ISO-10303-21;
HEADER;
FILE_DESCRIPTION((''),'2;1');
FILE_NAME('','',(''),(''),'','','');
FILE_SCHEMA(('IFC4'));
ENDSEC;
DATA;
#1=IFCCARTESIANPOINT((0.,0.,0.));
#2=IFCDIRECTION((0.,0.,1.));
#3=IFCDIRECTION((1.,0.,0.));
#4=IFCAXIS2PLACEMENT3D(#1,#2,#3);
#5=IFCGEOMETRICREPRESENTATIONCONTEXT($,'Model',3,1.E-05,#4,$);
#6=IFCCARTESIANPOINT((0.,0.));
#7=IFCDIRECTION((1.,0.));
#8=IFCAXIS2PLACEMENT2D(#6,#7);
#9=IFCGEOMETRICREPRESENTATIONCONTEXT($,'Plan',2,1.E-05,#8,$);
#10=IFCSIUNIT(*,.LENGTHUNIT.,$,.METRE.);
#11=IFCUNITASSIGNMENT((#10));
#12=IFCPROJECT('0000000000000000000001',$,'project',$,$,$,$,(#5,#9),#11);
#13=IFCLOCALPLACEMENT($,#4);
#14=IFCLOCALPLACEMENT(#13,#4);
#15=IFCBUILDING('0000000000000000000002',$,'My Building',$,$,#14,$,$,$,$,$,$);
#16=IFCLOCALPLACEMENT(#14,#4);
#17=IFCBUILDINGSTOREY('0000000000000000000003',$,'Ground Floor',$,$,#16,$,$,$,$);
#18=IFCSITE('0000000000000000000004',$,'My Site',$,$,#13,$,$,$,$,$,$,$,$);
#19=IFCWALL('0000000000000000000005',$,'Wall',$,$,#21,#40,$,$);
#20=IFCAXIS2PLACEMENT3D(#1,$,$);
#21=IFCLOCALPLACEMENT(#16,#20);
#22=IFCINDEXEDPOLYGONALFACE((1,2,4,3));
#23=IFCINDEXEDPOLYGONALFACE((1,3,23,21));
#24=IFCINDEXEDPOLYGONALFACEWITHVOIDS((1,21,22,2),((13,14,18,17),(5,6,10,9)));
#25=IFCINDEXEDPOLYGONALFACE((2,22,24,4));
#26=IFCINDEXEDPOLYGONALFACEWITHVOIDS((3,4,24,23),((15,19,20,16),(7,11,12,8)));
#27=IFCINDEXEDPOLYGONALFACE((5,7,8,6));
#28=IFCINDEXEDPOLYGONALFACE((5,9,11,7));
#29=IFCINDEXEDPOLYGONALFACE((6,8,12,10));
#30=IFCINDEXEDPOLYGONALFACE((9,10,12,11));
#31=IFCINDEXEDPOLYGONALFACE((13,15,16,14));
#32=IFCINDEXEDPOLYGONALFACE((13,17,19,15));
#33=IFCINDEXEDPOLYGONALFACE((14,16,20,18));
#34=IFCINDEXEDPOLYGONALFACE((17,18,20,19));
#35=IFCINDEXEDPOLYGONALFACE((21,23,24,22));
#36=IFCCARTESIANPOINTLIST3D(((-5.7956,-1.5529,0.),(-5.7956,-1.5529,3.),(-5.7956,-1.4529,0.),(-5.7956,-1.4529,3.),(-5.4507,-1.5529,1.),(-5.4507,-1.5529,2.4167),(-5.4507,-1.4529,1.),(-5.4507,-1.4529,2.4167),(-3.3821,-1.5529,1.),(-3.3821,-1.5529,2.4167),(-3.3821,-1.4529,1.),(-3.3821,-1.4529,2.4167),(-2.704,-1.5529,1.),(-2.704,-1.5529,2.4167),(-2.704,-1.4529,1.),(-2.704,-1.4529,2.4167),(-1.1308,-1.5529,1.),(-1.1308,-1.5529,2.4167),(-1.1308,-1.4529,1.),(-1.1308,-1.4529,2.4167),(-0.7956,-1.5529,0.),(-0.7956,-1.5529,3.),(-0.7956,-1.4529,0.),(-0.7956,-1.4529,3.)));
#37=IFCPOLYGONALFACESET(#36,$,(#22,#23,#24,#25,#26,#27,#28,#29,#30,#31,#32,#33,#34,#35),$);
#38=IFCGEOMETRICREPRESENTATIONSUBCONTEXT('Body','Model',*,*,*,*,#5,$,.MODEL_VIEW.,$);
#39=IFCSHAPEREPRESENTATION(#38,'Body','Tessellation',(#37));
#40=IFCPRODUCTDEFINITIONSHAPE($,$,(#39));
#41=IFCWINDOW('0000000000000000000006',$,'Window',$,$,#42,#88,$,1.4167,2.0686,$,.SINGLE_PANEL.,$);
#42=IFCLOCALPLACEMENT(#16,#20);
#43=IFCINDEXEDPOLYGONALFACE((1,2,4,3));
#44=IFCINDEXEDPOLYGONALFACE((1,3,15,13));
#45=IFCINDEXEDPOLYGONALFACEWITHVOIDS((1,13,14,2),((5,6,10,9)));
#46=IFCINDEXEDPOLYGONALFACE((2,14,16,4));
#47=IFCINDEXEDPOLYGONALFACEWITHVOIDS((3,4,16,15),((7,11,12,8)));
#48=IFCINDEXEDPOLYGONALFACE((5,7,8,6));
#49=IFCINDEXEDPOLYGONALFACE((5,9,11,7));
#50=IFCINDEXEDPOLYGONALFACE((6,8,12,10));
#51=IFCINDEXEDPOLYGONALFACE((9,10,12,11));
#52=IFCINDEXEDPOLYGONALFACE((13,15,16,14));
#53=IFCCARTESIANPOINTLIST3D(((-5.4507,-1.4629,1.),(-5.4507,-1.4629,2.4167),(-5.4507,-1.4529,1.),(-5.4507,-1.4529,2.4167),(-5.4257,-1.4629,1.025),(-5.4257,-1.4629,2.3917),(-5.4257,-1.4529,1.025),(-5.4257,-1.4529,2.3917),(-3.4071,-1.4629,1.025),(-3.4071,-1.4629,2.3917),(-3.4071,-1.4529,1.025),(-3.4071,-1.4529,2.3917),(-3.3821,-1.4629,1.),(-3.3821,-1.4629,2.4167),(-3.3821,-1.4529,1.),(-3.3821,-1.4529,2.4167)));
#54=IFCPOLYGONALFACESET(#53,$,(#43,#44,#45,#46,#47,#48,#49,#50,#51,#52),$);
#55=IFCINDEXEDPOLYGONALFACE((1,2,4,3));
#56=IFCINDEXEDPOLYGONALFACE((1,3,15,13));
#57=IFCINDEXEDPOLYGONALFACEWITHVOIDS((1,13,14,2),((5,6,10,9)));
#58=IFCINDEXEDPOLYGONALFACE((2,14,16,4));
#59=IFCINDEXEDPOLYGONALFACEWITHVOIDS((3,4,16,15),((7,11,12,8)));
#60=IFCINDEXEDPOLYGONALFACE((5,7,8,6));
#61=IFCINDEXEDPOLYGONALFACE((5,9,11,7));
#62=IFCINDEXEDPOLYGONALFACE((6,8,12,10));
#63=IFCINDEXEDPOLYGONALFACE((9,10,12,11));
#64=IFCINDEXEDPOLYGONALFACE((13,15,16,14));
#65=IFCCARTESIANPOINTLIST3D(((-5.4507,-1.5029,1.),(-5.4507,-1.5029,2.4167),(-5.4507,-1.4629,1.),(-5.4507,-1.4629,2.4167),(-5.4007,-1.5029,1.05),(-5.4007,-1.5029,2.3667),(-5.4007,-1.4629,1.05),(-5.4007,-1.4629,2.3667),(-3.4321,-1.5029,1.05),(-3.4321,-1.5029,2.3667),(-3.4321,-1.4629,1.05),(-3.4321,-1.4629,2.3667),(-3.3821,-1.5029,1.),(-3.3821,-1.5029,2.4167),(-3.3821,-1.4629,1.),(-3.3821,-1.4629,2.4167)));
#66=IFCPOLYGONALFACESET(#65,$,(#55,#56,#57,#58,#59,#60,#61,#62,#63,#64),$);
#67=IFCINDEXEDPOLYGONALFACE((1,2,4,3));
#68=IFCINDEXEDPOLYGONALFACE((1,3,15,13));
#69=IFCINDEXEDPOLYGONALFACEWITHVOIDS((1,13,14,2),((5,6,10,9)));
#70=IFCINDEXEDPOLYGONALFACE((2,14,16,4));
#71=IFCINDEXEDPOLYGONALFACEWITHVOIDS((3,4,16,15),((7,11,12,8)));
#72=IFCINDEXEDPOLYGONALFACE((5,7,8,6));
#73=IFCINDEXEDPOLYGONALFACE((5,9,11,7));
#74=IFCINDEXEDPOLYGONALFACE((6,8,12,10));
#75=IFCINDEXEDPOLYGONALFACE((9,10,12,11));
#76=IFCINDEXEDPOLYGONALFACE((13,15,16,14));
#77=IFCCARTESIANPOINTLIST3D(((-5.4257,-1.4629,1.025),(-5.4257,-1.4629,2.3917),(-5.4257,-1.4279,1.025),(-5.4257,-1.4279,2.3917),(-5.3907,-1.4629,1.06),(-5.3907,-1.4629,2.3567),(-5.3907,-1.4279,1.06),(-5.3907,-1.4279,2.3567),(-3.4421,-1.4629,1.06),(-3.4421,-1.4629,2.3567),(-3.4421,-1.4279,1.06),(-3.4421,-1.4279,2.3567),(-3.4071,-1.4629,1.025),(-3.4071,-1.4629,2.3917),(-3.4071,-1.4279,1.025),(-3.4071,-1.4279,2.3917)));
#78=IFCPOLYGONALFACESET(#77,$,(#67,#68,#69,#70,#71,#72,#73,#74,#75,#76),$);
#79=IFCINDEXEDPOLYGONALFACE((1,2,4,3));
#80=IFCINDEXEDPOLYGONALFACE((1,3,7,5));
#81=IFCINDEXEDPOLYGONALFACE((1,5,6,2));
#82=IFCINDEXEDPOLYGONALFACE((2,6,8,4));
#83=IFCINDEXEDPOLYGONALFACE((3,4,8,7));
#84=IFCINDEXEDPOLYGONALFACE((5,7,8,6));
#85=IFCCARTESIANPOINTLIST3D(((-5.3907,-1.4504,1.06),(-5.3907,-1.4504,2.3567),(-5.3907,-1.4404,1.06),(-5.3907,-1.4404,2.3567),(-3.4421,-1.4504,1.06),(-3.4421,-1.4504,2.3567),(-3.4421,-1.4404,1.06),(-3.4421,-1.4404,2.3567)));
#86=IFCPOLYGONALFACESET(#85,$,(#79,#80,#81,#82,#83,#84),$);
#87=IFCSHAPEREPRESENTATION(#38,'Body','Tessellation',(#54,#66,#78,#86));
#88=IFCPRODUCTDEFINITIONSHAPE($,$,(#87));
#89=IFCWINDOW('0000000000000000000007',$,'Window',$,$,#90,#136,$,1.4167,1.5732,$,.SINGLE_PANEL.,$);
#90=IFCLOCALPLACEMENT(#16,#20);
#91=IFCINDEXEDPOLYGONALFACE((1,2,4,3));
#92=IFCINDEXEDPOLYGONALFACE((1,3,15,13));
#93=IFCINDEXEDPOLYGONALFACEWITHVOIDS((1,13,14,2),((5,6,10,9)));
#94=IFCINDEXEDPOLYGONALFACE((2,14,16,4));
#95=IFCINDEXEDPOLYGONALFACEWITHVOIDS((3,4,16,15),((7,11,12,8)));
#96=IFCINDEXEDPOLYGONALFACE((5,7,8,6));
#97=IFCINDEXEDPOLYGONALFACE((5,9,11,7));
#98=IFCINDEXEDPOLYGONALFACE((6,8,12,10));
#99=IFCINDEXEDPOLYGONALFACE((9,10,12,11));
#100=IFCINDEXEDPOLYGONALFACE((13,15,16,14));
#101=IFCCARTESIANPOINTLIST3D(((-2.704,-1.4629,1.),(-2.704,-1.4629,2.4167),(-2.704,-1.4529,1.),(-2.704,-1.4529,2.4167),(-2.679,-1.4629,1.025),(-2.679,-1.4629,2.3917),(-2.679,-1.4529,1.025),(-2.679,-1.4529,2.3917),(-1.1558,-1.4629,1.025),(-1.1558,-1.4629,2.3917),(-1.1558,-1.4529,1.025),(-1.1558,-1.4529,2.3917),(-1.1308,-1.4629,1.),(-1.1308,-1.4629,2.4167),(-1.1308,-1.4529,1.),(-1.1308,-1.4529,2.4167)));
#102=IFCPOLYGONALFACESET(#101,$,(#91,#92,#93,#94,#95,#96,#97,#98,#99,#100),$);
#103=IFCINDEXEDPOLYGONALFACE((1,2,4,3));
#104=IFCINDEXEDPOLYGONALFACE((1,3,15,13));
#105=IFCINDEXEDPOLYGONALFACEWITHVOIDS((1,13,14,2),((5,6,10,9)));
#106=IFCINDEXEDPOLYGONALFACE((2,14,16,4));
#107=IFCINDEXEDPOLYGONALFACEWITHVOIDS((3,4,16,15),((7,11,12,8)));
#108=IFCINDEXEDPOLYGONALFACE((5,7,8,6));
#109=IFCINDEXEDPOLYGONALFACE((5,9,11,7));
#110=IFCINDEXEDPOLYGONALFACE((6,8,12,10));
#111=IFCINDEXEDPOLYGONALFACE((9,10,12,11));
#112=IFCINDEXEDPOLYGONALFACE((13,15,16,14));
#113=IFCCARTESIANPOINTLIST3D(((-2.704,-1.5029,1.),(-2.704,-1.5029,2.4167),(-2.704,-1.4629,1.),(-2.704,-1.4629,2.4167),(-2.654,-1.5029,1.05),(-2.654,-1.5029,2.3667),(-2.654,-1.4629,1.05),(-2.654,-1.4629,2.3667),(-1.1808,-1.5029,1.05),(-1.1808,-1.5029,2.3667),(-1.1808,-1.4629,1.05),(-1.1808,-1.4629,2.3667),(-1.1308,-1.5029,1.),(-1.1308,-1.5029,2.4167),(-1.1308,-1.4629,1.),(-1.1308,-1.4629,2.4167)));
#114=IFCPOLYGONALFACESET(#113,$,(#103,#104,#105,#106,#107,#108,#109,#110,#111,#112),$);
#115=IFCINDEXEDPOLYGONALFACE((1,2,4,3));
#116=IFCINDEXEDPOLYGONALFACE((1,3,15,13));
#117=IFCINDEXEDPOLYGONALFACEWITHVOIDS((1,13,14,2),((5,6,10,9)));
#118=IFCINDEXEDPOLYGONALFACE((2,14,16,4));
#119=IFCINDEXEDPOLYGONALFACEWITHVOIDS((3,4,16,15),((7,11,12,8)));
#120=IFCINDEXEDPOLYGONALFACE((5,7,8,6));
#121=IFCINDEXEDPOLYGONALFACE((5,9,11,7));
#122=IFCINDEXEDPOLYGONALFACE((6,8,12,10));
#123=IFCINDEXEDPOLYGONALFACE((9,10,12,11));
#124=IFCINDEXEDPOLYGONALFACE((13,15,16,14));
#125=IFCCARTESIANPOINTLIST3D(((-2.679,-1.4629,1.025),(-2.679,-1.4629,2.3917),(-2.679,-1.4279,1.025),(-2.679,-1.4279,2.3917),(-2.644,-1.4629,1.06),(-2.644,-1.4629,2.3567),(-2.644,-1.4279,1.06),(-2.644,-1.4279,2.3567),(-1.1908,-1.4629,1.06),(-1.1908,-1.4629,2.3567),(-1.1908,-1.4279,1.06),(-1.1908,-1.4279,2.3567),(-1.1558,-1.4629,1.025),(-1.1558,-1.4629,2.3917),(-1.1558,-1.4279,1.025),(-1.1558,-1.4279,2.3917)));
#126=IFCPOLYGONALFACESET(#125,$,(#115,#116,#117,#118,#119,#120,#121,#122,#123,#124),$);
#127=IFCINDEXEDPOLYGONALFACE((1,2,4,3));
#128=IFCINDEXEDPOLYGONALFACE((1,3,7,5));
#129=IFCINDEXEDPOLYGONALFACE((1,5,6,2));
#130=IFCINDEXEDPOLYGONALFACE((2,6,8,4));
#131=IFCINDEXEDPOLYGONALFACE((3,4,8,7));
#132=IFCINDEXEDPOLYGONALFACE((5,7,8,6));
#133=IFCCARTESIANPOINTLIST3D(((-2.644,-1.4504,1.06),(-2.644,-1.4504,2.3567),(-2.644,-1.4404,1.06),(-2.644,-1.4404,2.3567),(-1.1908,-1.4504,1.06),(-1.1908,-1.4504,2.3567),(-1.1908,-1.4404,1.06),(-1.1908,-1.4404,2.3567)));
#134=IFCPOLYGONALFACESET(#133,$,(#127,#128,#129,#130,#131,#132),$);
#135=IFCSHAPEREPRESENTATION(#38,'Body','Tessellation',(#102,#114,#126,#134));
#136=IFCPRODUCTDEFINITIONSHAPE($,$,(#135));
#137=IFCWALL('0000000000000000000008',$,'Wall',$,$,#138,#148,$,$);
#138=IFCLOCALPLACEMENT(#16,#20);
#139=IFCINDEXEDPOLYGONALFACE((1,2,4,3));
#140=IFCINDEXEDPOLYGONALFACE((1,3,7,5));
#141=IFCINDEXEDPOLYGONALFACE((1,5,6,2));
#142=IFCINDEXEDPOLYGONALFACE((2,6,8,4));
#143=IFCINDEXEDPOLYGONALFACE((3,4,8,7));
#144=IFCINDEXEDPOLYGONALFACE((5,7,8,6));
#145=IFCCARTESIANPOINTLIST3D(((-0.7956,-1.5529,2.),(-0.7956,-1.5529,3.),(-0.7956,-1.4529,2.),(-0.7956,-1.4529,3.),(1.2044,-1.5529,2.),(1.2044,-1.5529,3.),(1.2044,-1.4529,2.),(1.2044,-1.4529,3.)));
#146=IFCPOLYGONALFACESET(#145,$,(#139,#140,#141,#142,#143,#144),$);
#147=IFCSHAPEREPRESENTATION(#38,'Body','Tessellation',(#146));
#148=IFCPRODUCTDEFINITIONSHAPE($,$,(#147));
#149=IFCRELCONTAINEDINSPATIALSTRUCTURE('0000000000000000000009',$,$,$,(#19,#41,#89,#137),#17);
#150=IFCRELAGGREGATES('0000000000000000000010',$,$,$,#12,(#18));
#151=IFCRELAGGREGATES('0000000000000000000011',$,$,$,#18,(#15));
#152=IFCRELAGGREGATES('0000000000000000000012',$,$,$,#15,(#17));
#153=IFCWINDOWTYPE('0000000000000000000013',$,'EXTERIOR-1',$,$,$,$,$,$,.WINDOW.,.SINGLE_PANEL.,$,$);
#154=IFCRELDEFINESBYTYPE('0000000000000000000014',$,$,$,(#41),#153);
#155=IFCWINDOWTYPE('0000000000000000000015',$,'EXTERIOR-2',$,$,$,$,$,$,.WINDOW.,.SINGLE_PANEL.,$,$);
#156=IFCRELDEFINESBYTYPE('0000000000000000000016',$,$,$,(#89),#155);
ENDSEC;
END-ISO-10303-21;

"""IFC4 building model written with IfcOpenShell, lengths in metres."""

from ifc_helpers import new_model, entity, si_unit, frame, origin_with_axes, origin_2d_with_axis, place, context, subcontext, project, spatial, line, indexed_curve, outline, extrude, shape, source, transform, mapped, type_object, type_shapes, element, fill, save


model = new_model("IFC4")

# Units and contexts
model_context = context("Model", 3, precision=1e-05, world=origin_with_axes())
plan_context = context("Plan", 2, precision=1e-05, world=origin_2d_with_axis())
body_context_1 = subcontext(model_context, "Body", "Model", "MODEL_VIEW")
body_context_2 = subcontext(plan_context, "Body", "Plan", "PLAN_VIEW")
ifc_project = project(units=[si_unit("LENGTHUNIT", "METRE")], contexts=[model_context, plan_context])

# Site, building, storey
site_placement = place(None, origin_with_axes())
site = spatial("IfcSite", under=ifc_project, at=site_placement, Name="My Site")
building_placement = place(site_placement, origin_with_axes())
building = spatial("IfcBuilding", under=site, at=building_placement, Name="My Building")
storey_placement = place(building_placement, origin_with_axes())
storey = spatial("IfcBuildingStorey", under=building, at=storey_placement, Name="Ground Floor")

# Wall, openings, windows
wall_1_placement = place(storey_placement, frame((-5.7956, -1.5529, 0.0), z_axis=(0.0, 0.0, 1.0), x_axis=(1.0, 0.0, 0.0)))
wall_1 = element("IfcWall", 1, at=wall_1_placement, inside=storey, Name="Wall", context=body_context_1, shape_type="SweptSolid", body=[
    extrude(outline(indexed_curve([(0.0, 0.0), (0.0, 0.1), (5.0, 0.1), (5.0, 0.0)], segments=[line(1, 2, 3, 4, 1)])), origin_with_axes(), (0.0, 0.0, 1.0), 3.0),
])
shared_shape_1 = source(origin_with_axes(), body_context_1, "Body", "SweptSolid", [
    extrude(outline(indexed_curve([(0.0, 0.0), (2.0686, 0.0), (2.0686, 1.4167), (0.0, 1.4167)], segments=[line(1, 2, 3, 4, 1)])), frame((0.0, -0.6, 0.0), z_axis=(0.0, -1.0, 0.0), x_axis=(1.0, 0.0, 0.0)), (0.0, 0.0, -1.0), 1.2),
])
opening_1_placement = place(wall_1_placement, frame((0.3449, 0.0, 1.0), z_axis=(0.0, 0.0, 1.0), x_axis=(1.0, 0.0, 0.0)))
opening_1 = element("IfcOpeningElement", 2, at=opening_1_placement, cuts=wall_1, PredefinedType="OPENING", context=body_context_1, shape_type="MappedRepresentation", body=[
    mapped(shared_shape_1, transform((0.0, 0.0, 0.0), x_axis=(1.0, 0.0, 0.0), y_axis=(0.0, 1.0, 0.0), z_axis=(0.0, 0.0, 1.0), scale=1.0)),
])
shared_shape_2 = source(origin_with_axes(), body_context_1, "Body", "SweptSolid", [
    extrude(outline(indexed_curve([(0.0, 0.0), (1.5732, 0.0), (1.5732, 1.4167), (0.0, 1.4167)], segments=[line(1, 2, 3, 4, 1)])), frame((0.0, -0.6, 0.0), z_axis=(0.0, -1.0, 0.0), x_axis=(1.0, 0.0, 0.0)), (0.0, 0.0, -1.0), 1.2),
])
opening_2_placement = place(wall_1_placement, frame((3.0915, 0.0, 1.0), z_axis=(0.0, 0.0, 1.0), x_axis=(1.0, 0.0, 0.0)))
opening_2 = element("IfcOpeningElement", 3, at=opening_2_placement, cuts=wall_1, PredefinedType="OPENING", context=body_context_1, shape_type="MappedRepresentation", body=[
    mapped(shared_shape_2, transform((0.0, 0.0, 0.0), x_axis=(1.0, 0.0, 0.0), y_axis=(0.0, 1.0, 0.0), z_axis=(0.0, 0.0, 1.0), scale=1.0)),
])
window_type_1 = type_object("IfcWindowType", Name="EXTERIOR-1", PartitioningType="SINGLE_PANEL", PredefinedType="WINDOW")
shared_shape_3 = source(origin_with_axes(), body_context_1, "Body", "SweptSolid", [
    extrude(outline(indexed_curve([(0.0, 0.0), (2.0686, 0.0), (2.0686, 1.4167), (0.0, 1.4167)], segments=[line(1, 2, 3, 4, 1)]), holes=[indexed_curve([(0.025, 0.025), (2.0436, 0.025), (2.0436, 1.3917), (0.025, 1.3917)], segments=[line(1, 2, 3, 4, 1)])]), frame((0.0, 0.09, 0.0), z_axis=(0.0, -1.0, 0.0), x_axis=(1.0, 0.0, 0.0)), (0.0, 0.0, -1.0), 0.01),
    extrude(outline(indexed_curve([(0.0, 0.0), (2.0686, 0.0), (2.0686, 1.4167), (0.0, 1.4167)], segments=[line(1, 2, 3, 4, 1)]), holes=[indexed_curve([(0.05, 0.05), (2.0186, 0.05), (2.0186, 1.3667), (0.05, 1.3667)], segments=[line(1, 2, 3, 4, 1)])]), frame((0.0, 0.05, 0.0), z_axis=(0.0, -1.0, 0.0), x_axis=(1.0, 0.0, 0.0)), (0.0, 0.0, -1.0), 0.04),
    extrude(outline(indexed_curve([(0.0, 0.0), (2.0186, 0.0), (2.0186, 1.3667), (0.0, 1.3667)], segments=[line(1, 2, 3, 4, 1)]), holes=[indexed_curve([(0.035, 0.035), (1.9836, 0.035), (1.9836, 1.3317), (0.035, 1.3317)], segments=[line(1, 2, 3, 4, 1)])]), frame((0.025, 0.09, 0.025), z_axis=(0.0, -1.0, 0.0), x_axis=(1.0, 0.0, 0.0)), (0.0, 0.0, -1.0), 0.035),
    extrude(outline(indexed_curve([(0.035, 0.035), (1.9836, 0.035), (1.9836, 1.3317), (0.035, 1.3317)], segments=[line(1, 2, 3, 4, 1)])), frame((0.025, 0.1025, 0.025), z_axis=(0.0, -1.0, 0.0), x_axis=(1.0, 0.0, 0.0)), (0.0, 0.0, -1.0), 0.01),
])
shared_shape_4 = source(origin_with_axes(), body_context_2, "Body", "Curve2D", [
    entity("IfcIndexedPolyCurve", entity("IfcCartesianPointList2D", [[0.05, 0.05], [2.0186, 0.05]])),
    entity("IfcIndexedPolyCurve", entity("IfcCartesianPointList2D", [[0.0, 0.1], [0.025, 0.1], [0.025, 0.09], [0.05, 0.09], [0.05, 0.05], [0.0, 0.05]]), [entity("IfcLineIndex", [1, 2, 3, 4, 5, 6, 1])]),
    entity("IfcIndexedPolyCurve", entity("IfcCartesianPointList2D", [[2.0686, 0.1], [2.0436, 0.1], [2.0436, 0.09], [2.0186, 0.09], [2.0186, 0.05], [2.0686, 0.05]]), [entity("IfcLineIndex", [1, 2, 3, 4, 5, 6, 1])]),
    entity("IfcIndexedPolyCurve", entity("IfcCartesianPointList2D", [[0.025, 0.09], [0.06, 0.09], [0.06, 0.125], [0.025, 0.125]]), [entity("IfcLineIndex", [1, 2, 3, 4, 1])]),
    entity("IfcIndexedPolyCurve", entity("IfcCartesianPointList2D", [[2.0436, 0.09], [2.0086, 0.09], [2.0086, 0.125], [2.0436, 0.125]]), [entity("IfcLineIndex", [1, 2, 3, 4, 1])]),
    entity("IfcIndexedPolyCurve", entity("IfcCartesianPointList2D", [[0.06, 0.09], [2.0086, 0.09]])),
    entity("IfcIndexedPolyCurve", entity("IfcCartesianPointList2D", [[0.06, 0.125], [2.0086, 0.125]])),
    entity("IfcIndexedPolyCurve", entity("IfcCartesianPointList2D", [[0.06, 0.1075], [2.0086, 0.1075]])),
])
type_shapes(window_type_1, [shared_shape_3, shared_shape_4])
window_1_placement = place(opening_1_placement, origin_with_axes())
window_1 = element("IfcWindow", 4, at=window_1_placement, inside=storey, type_object=window_type_1, Name="Window", OverallHeight=1.4167, OverallWidth=2.0686, PartitioningType="SINGLE_PANEL", shapes=[
    shape(body_context_1, "Body", "MappedRepresentation", [mapped(shared_shape_3, transform((0.0, 0.0, 0.0), x_axis=(1.0, 0.0, 0.0), y_axis=(0.0, 1.0, 0.0), z_axis=(0.0, 0.0, 1.0), scale=1.0))]),
    shape(body_context_2, "Body", "MappedRepresentation", [mapped(shared_shape_4, transform((0.0, 0.0, 0.0), x_axis=(1.0, 0.0, 0.0), y_axis=(0.0, 1.0, 0.0), z_axis=(0.0, 0.0, 1.0), scale=1.0))]),
])
fill(opening_1, window_1)
window_type_2 = type_object("IfcWindowType", Name="EXTERIOR-2", PartitioningType="SINGLE_PANEL", PredefinedType="WINDOW")
shared_shape_5 = source(origin_with_axes(), body_context_1, "Body", "SweptSolid", [
    extrude(outline(indexed_curve([(0.0, 0.0), (1.5732, 0.0), (1.5732, 1.4167), (0.0, 1.4167)], segments=[line(1, 2, 3, 4, 1)]), holes=[indexed_curve([(0.025, 0.025), (1.5482, 0.025), (1.5482, 1.3917), (0.025, 1.3917)], segments=[line(1, 2, 3, 4, 1)])]), frame((0.0, 0.09, 0.0), z_axis=(0.0, -1.0, 0.0), x_axis=(1.0, 0.0, 0.0)), (0.0, 0.0, -1.0), 0.01),
    extrude(outline(indexed_curve([(0.0, 0.0), (1.5732, 0.0), (1.5732, 1.4167), (0.0, 1.4167)], segments=[line(1, 2, 3, 4, 1)]), holes=[indexed_curve([(0.05, 0.05), (1.5232, 0.05), (1.5232, 1.3667), (0.05, 1.3667)], segments=[line(1, 2, 3, 4, 1)])]), frame((0.0, 0.05, 0.0), z_axis=(0.0, -1.0, 0.0), x_axis=(1.0, 0.0, 0.0)), (0.0, 0.0, -1.0), 0.04),
    extrude(outline(indexed_curve([(0.0, 0.0), (1.5232, 0.0), (1.5232, 1.3667), (0.0, 1.3667)], segments=[line(1, 2, 3, 4, 1)]), holes=[indexed_curve([(0.035, 0.035), (1.4882, 0.035), (1.4882, 1.3317), (0.035, 1.3317)], segments=[line(1, 2, 3, 4, 1)])]), frame((0.025, 0.09, 0.025), z_axis=(0.0, -1.0, 0.0), x_axis=(1.0, 0.0, 0.0)), (0.0, 0.0, -1.0), 0.035),
    extrude(outline(indexed_curve([(0.035, 0.035), (1.4882, 0.035), (1.4882, 1.3317), (0.035, 1.3317)], segments=[line(1, 2, 3, 4, 1)])), frame((0.025, 0.1025, 0.025), z_axis=(0.0, -1.0, 0.0), x_axis=(1.0, 0.0, 0.0)), (0.0, 0.0, -1.0), 0.01),
])
shared_shape_6 = source(origin_with_axes(), body_context_2, "Body", "Curve2D", [
    entity("IfcIndexedPolyCurve", entity("IfcCartesianPointList2D", [[0.05, 0.05], [1.5232, 0.05]])),
    entity("IfcIndexedPolyCurve", entity("IfcCartesianPointList2D", [[0.0, 0.1], [0.025, 0.1], [0.025, 0.09], [0.05, 0.09], [0.05, 0.05], [0.0, 0.05]]), [entity("IfcLineIndex", [1, 2, 3, 4, 5, 6, 1])]),
    entity("IfcIndexedPolyCurve", entity("IfcCartesianPointList2D", [[1.5732, 0.1], [1.5482, 0.1], [1.5482, 0.09], [1.5232, 0.09], [1.5232, 0.05], [1.5732, 0.05]]), [entity("IfcLineIndex", [1, 2, 3, 4, 5, 6, 1])]),
    entity("IfcIndexedPolyCurve", entity("IfcCartesianPointList2D", [[0.025, 0.09], [0.06, 0.09], [0.06, 0.125], [0.025, 0.125]]), [entity("IfcLineIndex", [1, 2, 3, 4, 1])]),
    entity("IfcIndexedPolyCurve", entity("IfcCartesianPointList2D", [[1.5482, 0.09], [1.5132, 0.09], [1.5132, 0.125], [1.5482, 0.125]]), [entity("IfcLineIndex", [1, 2, 3, 4, 1])]),
    entity("IfcIndexedPolyCurve", entity("IfcCartesianPointList2D", [[0.06, 0.09], [1.5132, 0.09]])),
    entity("IfcIndexedPolyCurve", entity("IfcCartesianPointList2D", [[0.06, 0.125], [1.5132, 0.125]])),
    entity("IfcIndexedPolyCurve", entity("IfcCartesianPointList2D", [[0.06, 0.1075], [1.5132, 0.1075]])),
])
type_shapes(window_type_2, [shared_shape_5, shared_shape_6])
window_2_placement = place(opening_2_placement, origin_with_axes())
window_2 = element("IfcWindow", 5, at=window_2_placement, inside=storey, type_object=window_type_2, Name="Window", OverallHeight=1.4167, OverallWidth=1.5732, PartitioningType="SINGLE_PANEL", shapes=[
    shape(body_context_1, "Body", "MappedRepresentation", [mapped(shared_shape_5, transform((0.0, 0.0, 0.0), x_axis=(1.0, 0.0, 0.0), y_axis=(0.0, 1.0, 0.0), z_axis=(0.0, 0.0, 1.0), scale=1.0))]),
    shape(body_context_2, "Body", "MappedRepresentation", [mapped(shared_shape_6, transform((0.0, 0.0, 0.0), x_axis=(1.0, 0.0, 0.0), y_axis=(0.0, 1.0, 0.0), z_axis=(0.0, 0.0, 1.0), scale=1.0))]),
])
fill(opening_2, window_2)

# Wall
wall_2_placement = place(storey_placement, frame((-0.7956, -1.5529, 2.0), z_axis=(0.0, 0.0, 1.0), x_axis=(1.0, 0.0, 0.0)))
element("IfcWall", 6, at=wall_2_placement, inside=storey, Name="Wall", context=body_context_1, shape_type="SweptSolid", body=[
    extrude(outline(indexed_curve([(0.0, 0.0), (0.0, 0.1), (2.0, 0.1), (2.0, 0.0)], segments=[line(1, 2, 3, 4, 1)])), origin_with_axes(), (0.0, 0.0, 1.0), 1.0),
])

save(model, "model.ifc")
